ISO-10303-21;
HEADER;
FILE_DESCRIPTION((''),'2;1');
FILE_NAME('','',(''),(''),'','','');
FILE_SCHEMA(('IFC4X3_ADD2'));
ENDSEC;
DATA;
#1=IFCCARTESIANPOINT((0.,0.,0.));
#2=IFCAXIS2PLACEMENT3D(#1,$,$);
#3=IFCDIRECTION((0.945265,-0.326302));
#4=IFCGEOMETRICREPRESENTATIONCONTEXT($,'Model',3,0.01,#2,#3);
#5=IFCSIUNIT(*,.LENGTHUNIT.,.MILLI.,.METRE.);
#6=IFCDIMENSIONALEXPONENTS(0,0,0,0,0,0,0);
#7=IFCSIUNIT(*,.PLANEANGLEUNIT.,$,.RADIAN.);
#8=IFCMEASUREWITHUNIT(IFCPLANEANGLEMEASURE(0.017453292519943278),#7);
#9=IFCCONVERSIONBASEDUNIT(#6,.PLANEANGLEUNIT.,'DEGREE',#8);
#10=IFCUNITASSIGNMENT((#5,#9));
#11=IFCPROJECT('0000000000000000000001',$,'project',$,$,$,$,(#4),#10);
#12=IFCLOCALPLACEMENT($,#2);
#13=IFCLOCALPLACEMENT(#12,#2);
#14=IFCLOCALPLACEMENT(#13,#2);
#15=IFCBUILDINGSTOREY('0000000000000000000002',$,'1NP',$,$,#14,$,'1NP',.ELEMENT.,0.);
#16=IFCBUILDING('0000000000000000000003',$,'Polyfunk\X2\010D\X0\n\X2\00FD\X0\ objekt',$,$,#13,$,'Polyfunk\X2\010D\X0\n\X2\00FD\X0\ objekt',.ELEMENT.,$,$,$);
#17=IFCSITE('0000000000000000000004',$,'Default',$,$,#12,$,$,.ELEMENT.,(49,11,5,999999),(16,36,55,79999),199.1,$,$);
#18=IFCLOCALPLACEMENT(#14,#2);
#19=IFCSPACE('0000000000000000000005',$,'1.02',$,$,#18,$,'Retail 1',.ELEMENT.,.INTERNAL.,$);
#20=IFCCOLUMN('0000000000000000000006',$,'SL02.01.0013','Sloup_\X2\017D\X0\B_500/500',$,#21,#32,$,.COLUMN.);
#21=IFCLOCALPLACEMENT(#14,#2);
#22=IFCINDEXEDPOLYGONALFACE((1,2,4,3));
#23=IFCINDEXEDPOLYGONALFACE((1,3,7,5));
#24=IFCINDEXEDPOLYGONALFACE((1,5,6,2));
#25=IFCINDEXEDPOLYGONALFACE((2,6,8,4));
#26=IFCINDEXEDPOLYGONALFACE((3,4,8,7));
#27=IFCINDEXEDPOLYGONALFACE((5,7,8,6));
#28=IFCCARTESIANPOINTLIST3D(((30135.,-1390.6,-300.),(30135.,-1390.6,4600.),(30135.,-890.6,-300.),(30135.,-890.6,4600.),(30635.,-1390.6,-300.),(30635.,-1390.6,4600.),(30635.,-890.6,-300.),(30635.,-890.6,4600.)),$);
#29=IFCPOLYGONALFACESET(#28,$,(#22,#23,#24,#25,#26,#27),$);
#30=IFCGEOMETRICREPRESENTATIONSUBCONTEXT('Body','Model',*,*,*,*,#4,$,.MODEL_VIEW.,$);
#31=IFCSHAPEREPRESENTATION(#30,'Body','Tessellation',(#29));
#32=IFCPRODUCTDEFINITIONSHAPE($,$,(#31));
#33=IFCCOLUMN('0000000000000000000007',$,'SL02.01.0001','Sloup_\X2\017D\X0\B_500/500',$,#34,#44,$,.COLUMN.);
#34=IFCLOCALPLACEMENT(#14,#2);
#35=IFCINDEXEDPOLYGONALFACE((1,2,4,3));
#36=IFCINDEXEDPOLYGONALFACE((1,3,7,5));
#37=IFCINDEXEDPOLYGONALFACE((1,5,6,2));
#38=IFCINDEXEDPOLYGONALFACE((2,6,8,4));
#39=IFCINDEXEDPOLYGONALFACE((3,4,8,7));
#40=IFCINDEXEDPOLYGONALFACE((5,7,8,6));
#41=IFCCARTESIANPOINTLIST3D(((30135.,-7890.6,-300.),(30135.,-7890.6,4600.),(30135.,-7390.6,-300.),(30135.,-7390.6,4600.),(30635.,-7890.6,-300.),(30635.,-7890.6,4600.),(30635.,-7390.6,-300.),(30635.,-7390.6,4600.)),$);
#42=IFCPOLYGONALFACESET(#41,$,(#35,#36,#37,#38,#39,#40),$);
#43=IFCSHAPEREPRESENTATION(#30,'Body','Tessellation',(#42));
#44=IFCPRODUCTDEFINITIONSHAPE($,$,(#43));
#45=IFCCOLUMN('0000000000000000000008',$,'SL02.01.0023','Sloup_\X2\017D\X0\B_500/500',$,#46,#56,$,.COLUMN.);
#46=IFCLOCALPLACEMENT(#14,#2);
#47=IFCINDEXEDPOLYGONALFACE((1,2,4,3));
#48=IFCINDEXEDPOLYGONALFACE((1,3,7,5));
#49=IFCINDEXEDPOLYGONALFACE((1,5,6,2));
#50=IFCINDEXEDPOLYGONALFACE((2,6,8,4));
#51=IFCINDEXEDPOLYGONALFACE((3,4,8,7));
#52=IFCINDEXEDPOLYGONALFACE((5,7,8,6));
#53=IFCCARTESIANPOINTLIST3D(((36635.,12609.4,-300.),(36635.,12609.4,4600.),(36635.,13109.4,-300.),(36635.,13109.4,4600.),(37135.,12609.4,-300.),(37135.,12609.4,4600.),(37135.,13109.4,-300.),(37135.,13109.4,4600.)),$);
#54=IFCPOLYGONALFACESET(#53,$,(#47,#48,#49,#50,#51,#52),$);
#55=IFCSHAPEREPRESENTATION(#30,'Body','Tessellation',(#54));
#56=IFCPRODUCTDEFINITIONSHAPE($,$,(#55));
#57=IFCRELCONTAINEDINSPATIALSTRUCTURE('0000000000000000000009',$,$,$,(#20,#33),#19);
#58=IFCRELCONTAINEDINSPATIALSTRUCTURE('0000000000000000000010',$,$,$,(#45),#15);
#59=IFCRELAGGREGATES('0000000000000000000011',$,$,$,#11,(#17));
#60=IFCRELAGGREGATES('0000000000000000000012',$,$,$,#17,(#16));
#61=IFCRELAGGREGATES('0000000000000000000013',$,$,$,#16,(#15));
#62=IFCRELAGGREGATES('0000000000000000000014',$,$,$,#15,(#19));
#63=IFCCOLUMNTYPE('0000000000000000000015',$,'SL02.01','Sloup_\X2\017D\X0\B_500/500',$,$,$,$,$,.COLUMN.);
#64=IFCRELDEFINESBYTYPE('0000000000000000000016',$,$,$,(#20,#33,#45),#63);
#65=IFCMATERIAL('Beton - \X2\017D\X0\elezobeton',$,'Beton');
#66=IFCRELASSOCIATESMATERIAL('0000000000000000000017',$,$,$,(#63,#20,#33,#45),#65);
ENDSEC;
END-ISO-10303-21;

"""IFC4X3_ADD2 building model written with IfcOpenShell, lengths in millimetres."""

from ifc_helpers import new_model, entity, si_unit, converted_unit, direction, frame, frame_2d, origin, origin_2d_with_axis, place, context, subcontext, project, spatial, rectangle, extrude, source, transform, mapped, material, material_profile, profile_set, profile_usage, type_object, element, save


model = new_model("IFC4X3_ADD2")

# Units and contexts
model_context = context("Model", 3, precision=0.01, world=origin(), true_north=direction((0.945265, -0.326302)))
body_context = subcontext(model_context, "Body", "Model", "MODEL_VIEW")
ifc_project = project(units=[si_unit("LENGTHUNIT", "METRE", prefix="MILLI"), converted_unit("PLANEANGLEUNIT", "DEGREE", entity("IfcPlaneAngleMeasure", 0.017453292519943278), si_unit("PLANEANGLEUNIT", "RADIAN"), dimensions=[0, 0, 0, 0, 0, 0, 0])], contexts=[model_context])

# Site, building, storey
site_placement = place(None, origin())
site = spatial("IfcSite", under=ifc_project, at=site_placement, Name="Default", CompositionType="ELEMENT", RefLatitude=(49, 11, 5, 999999), RefLongitude=(16, 36, 55, 79999), RefElevation=199.1)
building_placement = place(site_placement, origin())
building = spatial("IfcBuilding", under=site, at=building_placement, Name="Polyfunkčný objekt", LongName="Polyfunkčný objekt", CompositionType="ELEMENT")
storey_placement = place(building_placement, origin())
storey = spatial("IfcBuildingStorey", under=building, at=storey_placement, Name="1NP", LongName="1NP", CompositionType="ELEMENT", Elevation=0.0)

# Shared definitions
ifc_material_1 = material(Name="Beton - Železobeton", Category="Beton")
ifc_material_profile = material_profile(ifc_material_1, rectangle(XDim=500.0, YDim=500.0, at=frame_2d((0.0, 0.0), x_axis=(1.0, 0.0))), Name="Sloup_ŽB_500/500")
ifc_profile_set = profile_set([ifc_material_profile], Name="Sloup_ŽB_500/500")
ifc_profile_usage = profile_usage(ifc_profile_set)
column_type = type_object("IfcColumnType", Name="SL02.01", Description="Sloup_ŽB_500/500", PredefinedType="COLUMN", material=ifc_profile_set)

# Shared definitions
space_1_placement = place(storey_placement, origin())
space_1 = spatial("IfcSpace", under=storey, at=space_1_placement, Name="1.02", LongName="Retail 1", CompositionType="ELEMENT", PredefinedType="INTERNAL")

# Columns
shared_shape_1 = source(origin(), body_context, "Body", "SweptSolid", [
    extrude(rectangle(XDim=500.0, YDim=500.0, at=origin_2d_with_axis()), frame((30385.0, -1140.6, -300.0), z_axis=(0.0, 0.0, 1.0), x_axis=(0.0, -1.0, 0.0)), (0.0, 0.0, 1.0), 4900.0),
])
column_1_placement = place(storey_placement, origin())
element("IfcColumn", 1, at=column_1_placement, inside=space_1, type_object=column_type, material=ifc_profile_usage, Name="SL02.01.0013", Description="Sloup_ŽB_500/500", PredefinedType="COLUMN", context=body_context, shape_type="MappedRepresentation", body=[
    mapped(shared_shape_1, transform((0.0, 0.0, 0.0), scale=1.0)),
])
shared_shape_2 = source(origin(), body_context, "Body", "SweptSolid", [
    extrude(rectangle(XDim=500.0, YDim=500.0, at=frame_2d((0.0, 0.0), x_axis=(1.0, 0.0))), frame((30385.0, -7640.6, -300.0), z_axis=(0.0, 0.0, 1.0), x_axis=(-1.0, 0.0, 0.0)), (0.0, 0.0, 1.0), 4900.0),
])
column_2_placement = place(storey_placement, origin())
element("IfcColumn", 2, at=column_2_placement, inside=space_1, type_object=column_type, material=ifc_profile_usage, Name="SL02.01.0001", Description="Sloup_ŽB_500/500", PredefinedType="COLUMN", context=body_context, shape_type="MappedRepresentation", body=[
    mapped(shared_shape_2, transform((0.0, 0.0, 0.0), scale=1.0)),
])
shared_shape_3 = source(origin(), body_context, "Body", "SweptSolid", [
    extrude(rectangle(XDim=500.0, YDim=500.0, at=frame_2d((-83.3, 0.0), x_axis=(1.0, 0.0))), frame((36885.0, 12776.1, -300.0), z_axis=(0.0, 0.0, 1.0), x_axis=(0.0, -1.0, 0.0)), (0.0, 0.0, 1.0), 4900.0),
])
column_3_placement = place(storey_placement, origin())
element("IfcColumn", 3, at=column_3_placement, inside=storey, type_object=column_type, material=ifc_profile_usage, Name="SL02.01.0023", Description="Sloup_ŽB_500/500", PredefinedType="COLUMN", context=body_context, shape_type="MappedRepresentation", body=[
    mapped(shared_shape_3, transform((0.0, 0.0, 0.0), scale=1.0)),
])

save(model, "model.ifc")
